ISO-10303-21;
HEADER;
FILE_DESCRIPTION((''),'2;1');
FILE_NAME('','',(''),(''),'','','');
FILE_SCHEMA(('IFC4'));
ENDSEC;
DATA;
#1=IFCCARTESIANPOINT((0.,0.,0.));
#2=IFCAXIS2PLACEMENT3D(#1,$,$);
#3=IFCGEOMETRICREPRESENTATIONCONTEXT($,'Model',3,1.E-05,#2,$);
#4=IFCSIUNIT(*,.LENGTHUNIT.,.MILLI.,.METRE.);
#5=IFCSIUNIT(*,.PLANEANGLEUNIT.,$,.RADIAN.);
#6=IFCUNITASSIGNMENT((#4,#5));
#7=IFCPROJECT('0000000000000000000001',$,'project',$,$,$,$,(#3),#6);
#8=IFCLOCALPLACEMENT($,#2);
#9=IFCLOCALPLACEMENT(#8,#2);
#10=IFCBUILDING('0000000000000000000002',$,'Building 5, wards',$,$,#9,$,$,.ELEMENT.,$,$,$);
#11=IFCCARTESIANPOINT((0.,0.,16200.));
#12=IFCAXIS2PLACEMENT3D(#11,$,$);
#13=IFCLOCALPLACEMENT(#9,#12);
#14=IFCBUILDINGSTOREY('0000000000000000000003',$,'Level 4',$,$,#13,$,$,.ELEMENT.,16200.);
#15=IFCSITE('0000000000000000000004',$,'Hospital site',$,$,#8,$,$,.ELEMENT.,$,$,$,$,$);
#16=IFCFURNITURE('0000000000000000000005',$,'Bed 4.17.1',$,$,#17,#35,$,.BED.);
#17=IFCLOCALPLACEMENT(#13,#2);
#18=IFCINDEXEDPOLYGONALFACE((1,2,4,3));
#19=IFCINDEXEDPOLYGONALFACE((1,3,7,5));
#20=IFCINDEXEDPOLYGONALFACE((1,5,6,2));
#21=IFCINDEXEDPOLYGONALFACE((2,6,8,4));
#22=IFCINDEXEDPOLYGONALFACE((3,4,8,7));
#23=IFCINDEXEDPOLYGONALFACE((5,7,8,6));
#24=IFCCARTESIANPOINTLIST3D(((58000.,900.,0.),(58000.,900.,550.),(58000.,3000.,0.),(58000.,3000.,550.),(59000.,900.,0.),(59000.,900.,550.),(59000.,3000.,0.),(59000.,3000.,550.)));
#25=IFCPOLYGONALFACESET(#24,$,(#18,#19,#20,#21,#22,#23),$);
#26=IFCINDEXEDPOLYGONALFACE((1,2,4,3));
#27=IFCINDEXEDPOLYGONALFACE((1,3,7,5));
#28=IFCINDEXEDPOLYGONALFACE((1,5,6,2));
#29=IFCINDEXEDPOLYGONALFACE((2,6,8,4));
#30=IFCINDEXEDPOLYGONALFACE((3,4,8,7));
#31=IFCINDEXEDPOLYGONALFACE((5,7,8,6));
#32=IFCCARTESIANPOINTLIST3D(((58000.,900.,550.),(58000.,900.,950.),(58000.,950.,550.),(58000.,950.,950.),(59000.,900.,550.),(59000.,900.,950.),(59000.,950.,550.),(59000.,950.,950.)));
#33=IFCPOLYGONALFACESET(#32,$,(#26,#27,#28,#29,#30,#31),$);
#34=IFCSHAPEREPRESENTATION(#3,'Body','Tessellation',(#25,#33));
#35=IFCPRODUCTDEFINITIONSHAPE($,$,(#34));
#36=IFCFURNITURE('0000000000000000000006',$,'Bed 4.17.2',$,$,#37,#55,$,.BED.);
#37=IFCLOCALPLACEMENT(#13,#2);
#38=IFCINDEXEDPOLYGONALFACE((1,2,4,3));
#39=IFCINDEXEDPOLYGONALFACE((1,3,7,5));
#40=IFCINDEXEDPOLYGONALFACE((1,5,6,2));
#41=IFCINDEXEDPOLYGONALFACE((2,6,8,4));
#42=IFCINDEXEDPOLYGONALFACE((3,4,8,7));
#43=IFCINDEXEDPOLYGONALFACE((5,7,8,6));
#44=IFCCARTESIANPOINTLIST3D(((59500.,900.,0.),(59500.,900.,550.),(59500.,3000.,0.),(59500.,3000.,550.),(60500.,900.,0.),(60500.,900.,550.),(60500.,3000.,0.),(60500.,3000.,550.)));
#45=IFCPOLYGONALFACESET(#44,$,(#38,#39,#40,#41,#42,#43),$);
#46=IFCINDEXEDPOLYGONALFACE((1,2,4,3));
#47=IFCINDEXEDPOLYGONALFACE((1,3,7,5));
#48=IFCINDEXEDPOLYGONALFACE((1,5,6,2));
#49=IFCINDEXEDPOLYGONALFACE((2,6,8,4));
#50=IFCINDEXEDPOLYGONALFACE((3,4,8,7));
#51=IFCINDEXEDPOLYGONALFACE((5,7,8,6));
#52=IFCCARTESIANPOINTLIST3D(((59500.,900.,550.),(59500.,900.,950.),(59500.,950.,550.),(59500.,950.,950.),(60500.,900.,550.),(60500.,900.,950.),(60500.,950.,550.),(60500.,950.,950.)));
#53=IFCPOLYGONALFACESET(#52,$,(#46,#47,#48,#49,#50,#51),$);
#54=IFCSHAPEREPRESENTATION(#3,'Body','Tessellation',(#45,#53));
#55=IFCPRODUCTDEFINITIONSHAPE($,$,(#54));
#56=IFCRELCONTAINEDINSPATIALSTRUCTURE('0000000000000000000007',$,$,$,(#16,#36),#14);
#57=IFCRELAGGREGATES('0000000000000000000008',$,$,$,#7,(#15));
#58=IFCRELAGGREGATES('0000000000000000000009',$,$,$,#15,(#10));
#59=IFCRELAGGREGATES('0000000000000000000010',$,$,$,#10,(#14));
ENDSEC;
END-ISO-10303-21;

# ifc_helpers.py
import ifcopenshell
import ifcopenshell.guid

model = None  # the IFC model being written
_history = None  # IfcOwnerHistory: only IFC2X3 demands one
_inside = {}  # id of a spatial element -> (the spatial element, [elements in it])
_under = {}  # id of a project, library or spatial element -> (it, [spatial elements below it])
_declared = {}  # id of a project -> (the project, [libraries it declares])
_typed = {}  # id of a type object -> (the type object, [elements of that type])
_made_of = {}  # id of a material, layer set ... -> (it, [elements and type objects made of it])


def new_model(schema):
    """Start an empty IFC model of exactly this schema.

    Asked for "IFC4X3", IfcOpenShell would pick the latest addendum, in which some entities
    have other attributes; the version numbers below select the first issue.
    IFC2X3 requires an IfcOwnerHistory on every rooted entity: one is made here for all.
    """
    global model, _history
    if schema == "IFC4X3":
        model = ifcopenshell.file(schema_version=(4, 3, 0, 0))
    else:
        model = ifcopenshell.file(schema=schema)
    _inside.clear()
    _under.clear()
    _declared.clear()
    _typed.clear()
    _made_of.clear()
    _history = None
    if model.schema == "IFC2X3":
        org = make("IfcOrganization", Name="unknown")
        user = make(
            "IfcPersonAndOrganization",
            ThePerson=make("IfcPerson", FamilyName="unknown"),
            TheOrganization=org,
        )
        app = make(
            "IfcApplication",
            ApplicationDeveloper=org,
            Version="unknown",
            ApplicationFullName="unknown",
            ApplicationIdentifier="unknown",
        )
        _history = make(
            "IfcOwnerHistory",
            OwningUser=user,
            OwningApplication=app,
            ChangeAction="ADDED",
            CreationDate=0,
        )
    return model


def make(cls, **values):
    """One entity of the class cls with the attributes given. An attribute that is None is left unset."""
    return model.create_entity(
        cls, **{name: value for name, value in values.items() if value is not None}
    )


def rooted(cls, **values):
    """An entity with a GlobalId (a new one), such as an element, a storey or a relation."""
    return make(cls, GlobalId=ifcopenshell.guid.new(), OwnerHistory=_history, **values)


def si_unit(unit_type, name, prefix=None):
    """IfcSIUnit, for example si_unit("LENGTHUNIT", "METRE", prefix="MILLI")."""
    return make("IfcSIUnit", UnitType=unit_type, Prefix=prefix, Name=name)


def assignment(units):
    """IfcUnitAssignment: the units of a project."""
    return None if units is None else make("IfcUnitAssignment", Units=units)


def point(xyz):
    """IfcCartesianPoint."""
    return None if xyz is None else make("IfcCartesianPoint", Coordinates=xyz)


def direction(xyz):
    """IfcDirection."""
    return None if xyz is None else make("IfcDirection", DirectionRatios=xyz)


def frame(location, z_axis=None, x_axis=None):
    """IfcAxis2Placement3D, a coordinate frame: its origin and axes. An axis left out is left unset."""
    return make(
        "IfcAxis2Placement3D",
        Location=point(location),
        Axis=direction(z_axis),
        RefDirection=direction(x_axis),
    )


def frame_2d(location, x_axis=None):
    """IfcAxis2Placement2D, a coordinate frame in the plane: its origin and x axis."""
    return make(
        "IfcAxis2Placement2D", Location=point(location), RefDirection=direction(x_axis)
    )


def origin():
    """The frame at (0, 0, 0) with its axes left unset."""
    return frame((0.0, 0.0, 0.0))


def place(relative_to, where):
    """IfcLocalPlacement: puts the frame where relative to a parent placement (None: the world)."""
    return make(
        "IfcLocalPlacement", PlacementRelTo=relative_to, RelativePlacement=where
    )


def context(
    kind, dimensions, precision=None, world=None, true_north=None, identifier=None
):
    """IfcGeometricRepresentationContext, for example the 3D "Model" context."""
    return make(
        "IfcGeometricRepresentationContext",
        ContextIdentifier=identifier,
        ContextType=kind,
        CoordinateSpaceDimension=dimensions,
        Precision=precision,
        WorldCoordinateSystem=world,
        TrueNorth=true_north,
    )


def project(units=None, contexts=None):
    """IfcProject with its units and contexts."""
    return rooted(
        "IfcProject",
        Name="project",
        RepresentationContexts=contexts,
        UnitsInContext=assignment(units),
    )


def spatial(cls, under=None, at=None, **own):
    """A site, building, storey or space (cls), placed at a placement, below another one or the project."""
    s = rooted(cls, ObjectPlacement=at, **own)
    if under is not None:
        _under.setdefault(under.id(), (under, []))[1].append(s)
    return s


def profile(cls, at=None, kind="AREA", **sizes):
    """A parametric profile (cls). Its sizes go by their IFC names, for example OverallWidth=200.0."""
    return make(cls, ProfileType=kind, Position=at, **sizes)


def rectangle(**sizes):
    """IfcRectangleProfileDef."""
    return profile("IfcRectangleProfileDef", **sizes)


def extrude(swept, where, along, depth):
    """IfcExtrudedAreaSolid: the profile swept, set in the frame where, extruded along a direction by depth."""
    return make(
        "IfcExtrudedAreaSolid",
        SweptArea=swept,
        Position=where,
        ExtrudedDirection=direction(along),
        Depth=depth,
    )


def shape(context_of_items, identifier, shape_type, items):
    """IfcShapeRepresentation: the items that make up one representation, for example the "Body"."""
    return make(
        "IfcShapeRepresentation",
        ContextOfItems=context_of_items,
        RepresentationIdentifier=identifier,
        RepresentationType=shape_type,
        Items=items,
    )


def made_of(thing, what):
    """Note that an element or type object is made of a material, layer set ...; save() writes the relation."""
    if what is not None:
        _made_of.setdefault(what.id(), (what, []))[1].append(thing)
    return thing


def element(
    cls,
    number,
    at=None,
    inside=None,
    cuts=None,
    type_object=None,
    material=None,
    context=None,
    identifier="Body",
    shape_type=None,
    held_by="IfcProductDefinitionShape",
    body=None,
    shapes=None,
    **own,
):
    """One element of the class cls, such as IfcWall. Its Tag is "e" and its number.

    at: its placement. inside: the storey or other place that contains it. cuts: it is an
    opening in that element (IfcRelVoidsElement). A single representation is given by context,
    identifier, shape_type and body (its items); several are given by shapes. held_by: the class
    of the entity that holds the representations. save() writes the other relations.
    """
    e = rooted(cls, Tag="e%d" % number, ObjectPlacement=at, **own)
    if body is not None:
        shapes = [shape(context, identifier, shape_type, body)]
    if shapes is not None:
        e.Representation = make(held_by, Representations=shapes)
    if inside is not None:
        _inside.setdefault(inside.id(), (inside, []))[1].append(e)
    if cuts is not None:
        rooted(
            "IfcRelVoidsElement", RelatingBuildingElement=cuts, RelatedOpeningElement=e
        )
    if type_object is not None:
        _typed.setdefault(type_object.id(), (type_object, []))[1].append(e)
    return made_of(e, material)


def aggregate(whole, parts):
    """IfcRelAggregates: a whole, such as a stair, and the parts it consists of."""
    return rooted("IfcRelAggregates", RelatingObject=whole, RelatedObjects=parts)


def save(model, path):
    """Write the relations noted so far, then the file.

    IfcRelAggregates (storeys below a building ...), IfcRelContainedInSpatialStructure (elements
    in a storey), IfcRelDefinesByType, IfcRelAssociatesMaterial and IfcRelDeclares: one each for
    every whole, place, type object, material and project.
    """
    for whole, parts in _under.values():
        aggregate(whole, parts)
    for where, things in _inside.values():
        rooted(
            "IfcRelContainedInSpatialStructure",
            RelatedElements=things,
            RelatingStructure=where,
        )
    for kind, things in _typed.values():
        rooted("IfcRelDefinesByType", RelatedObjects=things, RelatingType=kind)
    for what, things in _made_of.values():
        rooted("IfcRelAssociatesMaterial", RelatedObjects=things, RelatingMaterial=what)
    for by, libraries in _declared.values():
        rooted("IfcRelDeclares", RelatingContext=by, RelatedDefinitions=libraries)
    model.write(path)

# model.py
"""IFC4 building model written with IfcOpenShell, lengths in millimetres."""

from ifc_helpers import new_model, si_unit, frame, frame_2d, origin, place, context, project, spatial, rectangle, extrude, element, save


model = new_model("IFC4")

# Units and contexts
model_context = context("Model", 3, precision=1e-05, world=origin())
ifc_project = project(units=[si_unit("LENGTHUNIT", "METRE", prefix="MILLI"), si_unit("PLANEANGLEUNIT", "RADIAN")], contexts=[model_context])

# Site, building, storey
site_placement = place(None, origin())
site = spatial("IfcSite", under=ifc_project, at=site_placement, Name="Hospital site", CompositionType="ELEMENT")
building_placement = place(site_placement, origin())
building = spatial("IfcBuilding", under=site, at=building_placement, Name="Building 5, wards", CompositionType="ELEMENT")
storey_placement = place(building_placement, frame((0.0, 0.0, 16200.0)))
storey = spatial("IfcBuildingStorey", under=building, at=storey_placement, Name="Level 4", CompositionType="ELEMENT", Elevation=16200.0)

# Furniture
for number, where, name in (
    (1, (58000.0, 900.0, 0.0), "Bed 4.17.1"),
    (2, (59500.0, 900.0, 0.0), "Bed 4.17.2"),
):
    element("IfcFurniture", number, at=place(storey_placement, frame(where)), inside=storey, Name=name, PredefinedType="BED", context=model_context, shape_type="SweptSolid", body=[
        extrude(rectangle(XDim=1000.0, YDim=2100.0, at=frame_2d((500.0, 1050.0))), origin(), (0.0, 0.0, 1.0), 550.0),
        extrude(rectangle(XDim=1000.0, YDim=50.0, at=frame_2d((500.0, 25.0))), frame((0.0, 0.0, 550.0)), (0.0, 0.0, 1.0), 400.0),
    ])

save(model, "model.ifc")
